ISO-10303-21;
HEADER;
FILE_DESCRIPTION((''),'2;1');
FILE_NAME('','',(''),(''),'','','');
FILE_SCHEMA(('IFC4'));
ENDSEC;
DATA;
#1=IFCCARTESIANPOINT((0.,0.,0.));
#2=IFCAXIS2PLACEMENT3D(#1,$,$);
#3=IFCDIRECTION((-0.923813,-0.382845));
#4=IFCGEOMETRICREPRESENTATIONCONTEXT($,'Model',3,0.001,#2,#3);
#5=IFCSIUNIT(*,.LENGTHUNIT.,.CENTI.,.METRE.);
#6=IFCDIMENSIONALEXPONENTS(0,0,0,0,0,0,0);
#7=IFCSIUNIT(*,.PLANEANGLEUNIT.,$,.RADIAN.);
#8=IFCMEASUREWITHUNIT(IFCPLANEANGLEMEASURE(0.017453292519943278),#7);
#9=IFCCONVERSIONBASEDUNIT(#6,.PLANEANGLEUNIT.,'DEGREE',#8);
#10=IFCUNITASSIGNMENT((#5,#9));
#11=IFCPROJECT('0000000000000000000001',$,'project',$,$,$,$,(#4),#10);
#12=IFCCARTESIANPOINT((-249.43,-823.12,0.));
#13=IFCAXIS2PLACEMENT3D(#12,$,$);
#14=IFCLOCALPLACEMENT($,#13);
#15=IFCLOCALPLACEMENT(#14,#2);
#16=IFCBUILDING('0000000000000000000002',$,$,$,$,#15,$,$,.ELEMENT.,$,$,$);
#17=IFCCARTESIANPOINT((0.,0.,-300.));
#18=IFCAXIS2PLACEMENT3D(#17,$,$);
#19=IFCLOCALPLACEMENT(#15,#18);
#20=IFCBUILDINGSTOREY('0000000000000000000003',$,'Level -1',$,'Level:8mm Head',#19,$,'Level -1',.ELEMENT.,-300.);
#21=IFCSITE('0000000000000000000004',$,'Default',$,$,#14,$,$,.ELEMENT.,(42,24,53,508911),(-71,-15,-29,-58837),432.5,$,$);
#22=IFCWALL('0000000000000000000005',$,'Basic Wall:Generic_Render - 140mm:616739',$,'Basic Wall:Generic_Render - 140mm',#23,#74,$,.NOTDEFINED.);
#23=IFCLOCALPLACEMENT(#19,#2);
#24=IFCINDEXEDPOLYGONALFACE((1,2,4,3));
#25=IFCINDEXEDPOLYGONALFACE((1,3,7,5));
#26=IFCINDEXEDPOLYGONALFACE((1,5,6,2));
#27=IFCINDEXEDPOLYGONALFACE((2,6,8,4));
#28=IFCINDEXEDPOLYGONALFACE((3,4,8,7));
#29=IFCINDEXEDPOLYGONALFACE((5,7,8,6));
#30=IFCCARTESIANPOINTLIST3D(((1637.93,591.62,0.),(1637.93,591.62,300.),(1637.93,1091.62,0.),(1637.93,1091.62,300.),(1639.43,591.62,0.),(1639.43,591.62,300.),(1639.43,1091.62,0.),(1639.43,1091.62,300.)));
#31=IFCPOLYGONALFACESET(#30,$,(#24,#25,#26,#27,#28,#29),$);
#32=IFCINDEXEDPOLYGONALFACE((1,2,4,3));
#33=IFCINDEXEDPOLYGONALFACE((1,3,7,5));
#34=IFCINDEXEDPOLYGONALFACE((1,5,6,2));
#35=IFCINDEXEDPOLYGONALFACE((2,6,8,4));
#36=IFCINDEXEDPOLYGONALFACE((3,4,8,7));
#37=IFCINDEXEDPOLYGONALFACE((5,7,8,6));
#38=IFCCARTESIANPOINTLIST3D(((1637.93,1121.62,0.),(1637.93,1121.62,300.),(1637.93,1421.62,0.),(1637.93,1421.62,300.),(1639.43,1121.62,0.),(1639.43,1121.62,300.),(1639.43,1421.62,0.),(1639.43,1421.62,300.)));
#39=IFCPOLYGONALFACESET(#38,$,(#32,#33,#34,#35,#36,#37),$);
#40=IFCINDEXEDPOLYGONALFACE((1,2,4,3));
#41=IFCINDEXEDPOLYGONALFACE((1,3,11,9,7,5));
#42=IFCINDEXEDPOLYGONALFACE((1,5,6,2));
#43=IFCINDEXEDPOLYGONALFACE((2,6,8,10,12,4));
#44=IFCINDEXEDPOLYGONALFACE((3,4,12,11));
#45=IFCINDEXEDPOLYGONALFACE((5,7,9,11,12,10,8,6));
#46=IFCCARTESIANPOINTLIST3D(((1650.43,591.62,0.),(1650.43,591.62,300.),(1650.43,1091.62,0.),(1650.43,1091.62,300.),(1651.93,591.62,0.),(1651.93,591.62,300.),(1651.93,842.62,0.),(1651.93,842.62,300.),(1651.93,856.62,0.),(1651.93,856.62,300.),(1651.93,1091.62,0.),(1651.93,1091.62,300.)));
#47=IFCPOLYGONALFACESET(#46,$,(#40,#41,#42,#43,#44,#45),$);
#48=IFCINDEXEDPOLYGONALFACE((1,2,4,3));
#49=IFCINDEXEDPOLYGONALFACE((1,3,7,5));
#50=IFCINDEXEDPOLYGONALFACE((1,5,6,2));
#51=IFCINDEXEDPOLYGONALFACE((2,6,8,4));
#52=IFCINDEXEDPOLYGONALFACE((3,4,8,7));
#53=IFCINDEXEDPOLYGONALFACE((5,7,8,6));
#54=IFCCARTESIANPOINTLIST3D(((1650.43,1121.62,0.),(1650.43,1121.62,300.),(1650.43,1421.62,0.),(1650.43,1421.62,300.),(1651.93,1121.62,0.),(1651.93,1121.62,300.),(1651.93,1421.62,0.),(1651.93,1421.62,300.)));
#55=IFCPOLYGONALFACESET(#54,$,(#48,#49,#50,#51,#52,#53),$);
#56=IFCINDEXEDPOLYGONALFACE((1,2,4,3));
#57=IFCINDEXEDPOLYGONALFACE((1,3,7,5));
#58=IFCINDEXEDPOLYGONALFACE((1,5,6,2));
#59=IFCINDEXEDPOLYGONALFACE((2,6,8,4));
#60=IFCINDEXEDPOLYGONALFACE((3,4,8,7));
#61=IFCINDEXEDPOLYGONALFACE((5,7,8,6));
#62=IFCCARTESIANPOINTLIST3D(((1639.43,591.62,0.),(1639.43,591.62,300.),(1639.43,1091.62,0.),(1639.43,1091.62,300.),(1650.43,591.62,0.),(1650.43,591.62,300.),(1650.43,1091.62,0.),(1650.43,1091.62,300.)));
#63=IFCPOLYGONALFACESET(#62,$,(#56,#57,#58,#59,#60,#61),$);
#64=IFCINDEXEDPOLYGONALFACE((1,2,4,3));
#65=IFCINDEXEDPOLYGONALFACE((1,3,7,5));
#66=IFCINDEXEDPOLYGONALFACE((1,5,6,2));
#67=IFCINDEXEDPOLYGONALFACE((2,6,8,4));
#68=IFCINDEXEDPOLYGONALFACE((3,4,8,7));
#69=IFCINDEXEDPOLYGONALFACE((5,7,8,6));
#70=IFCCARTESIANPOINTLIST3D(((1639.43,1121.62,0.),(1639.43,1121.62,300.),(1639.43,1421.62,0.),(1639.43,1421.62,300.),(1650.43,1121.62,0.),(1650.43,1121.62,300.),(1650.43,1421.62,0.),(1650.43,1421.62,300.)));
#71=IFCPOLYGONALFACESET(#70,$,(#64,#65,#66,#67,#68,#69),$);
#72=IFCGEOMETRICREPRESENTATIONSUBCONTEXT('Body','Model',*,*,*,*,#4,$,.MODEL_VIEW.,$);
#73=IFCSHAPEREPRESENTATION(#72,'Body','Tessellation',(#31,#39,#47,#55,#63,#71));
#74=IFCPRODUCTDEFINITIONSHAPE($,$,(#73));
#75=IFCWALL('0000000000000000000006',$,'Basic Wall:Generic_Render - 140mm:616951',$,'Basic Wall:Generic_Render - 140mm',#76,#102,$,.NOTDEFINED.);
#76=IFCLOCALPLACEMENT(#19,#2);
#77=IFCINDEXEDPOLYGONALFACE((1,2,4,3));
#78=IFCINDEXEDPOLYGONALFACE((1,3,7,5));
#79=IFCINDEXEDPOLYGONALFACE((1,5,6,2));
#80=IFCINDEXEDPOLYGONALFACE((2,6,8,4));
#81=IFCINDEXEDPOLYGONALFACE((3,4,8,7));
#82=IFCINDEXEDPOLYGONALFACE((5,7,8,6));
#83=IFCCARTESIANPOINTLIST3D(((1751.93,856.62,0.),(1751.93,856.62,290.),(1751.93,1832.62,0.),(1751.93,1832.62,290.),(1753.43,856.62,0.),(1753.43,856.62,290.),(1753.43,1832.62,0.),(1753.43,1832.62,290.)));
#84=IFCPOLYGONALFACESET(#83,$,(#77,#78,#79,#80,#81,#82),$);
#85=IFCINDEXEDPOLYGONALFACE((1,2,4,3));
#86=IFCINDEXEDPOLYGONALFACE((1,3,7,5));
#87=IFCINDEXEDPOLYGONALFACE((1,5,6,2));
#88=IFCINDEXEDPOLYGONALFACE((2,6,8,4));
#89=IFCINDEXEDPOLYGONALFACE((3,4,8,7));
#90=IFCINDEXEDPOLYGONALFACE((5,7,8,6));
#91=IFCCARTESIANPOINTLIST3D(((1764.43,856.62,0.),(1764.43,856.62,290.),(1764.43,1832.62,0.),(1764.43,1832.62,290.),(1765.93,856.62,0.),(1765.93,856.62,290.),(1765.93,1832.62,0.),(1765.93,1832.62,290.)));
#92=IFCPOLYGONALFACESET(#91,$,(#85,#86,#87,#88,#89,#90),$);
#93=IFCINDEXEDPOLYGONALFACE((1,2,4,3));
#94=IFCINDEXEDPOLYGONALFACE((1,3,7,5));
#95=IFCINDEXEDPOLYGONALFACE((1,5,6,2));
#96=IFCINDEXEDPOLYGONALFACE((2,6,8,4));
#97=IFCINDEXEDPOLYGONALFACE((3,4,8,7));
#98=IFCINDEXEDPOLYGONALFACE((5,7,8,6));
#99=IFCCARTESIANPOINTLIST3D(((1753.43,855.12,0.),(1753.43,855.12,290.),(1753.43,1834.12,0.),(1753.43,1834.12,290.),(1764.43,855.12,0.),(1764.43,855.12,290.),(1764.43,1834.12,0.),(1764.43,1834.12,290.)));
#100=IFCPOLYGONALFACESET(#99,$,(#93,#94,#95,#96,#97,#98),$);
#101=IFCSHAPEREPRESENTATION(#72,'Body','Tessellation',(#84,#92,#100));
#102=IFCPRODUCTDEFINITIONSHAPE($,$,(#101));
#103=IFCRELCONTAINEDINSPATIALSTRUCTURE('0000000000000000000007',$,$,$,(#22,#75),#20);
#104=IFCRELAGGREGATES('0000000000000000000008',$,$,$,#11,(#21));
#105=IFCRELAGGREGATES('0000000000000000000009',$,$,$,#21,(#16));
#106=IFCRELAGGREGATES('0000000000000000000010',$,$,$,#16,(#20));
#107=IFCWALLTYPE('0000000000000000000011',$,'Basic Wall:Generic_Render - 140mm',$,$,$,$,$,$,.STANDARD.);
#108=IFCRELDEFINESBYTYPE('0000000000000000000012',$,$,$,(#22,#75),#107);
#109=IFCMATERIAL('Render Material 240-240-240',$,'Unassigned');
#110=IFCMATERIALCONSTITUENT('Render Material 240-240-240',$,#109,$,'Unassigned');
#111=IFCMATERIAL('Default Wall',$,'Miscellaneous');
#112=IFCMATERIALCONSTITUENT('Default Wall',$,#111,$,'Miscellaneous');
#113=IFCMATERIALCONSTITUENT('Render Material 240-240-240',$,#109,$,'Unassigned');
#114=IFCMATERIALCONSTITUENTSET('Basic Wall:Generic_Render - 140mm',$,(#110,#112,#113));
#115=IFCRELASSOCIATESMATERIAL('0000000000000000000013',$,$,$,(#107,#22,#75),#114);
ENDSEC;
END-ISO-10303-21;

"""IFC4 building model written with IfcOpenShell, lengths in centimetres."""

from ifc_helpers import new_model, entity, si_unit, converted_unit, direction, frame, origin, place, context, subcontext, project, spatial, indexed_curve, outline, extrude, material, constituent, constituent_set, type_object, element, save


model = new_model("IFC4")

# Units and contexts
model_context = context("Model", 3, precision=0.001, world=origin(), true_north=direction((-0.923813, -0.382845)))
body_context = subcontext(model_context, "Body", "Model", "MODEL_VIEW")
ifc_project = project(units=[si_unit("LENGTHUNIT", "METRE", prefix="CENTI"), converted_unit("PLANEANGLEUNIT", "DEGREE", entity("IfcPlaneAngleMeasure", 0.017453292519943278), si_unit("PLANEANGLEUNIT", "RADIAN"), dimensions=[0, 0, 0, 0, 0, 0, 0])], contexts=[model_context])

# Site, building, storey
site_placement = place(None, frame((-249.43, -823.12, 0.0)))
site = spatial("IfcSite", under=ifc_project, at=site_placement, Name="Default", CompositionType="ELEMENT", RefLatitude=(42, 24, 53, 508911), RefLongitude=(-71, -15, -29, -58837), RefElevation=432.5)
building_placement = place(site_placement, origin())
building = spatial("IfcBuilding", under=site, at=building_placement, CompositionType="ELEMENT")
storey_placement = place(building_placement, frame((0.0, 0.0, -300.0)))
storey = spatial("IfcBuildingStorey", under=building, at=storey_placement, Name="Level -1", ObjectType="Level:8mm Head", LongName="Level -1", CompositionType="ELEMENT", Elevation=-300.0)

# Shared definitions
ifc_material_1 = material(Name="Render Material 240-240-240", Category="Unassigned")
ifc_constituent_1 = constituent(ifc_material_1, Name="Render Material 240-240-240", Category="Unassigned")
ifc_material_2 = material(Name="Default Wall", Category="Miscellaneous")
ifc_constituent_2 = constituent(ifc_material_2, Name="Default Wall", Category="Miscellaneous")
ifc_constituent_3 = constituent(ifc_material_1, Name="Render Material 240-240-240", Category="Unassigned")
ifc_constituent_set_1 = constituent_set(constituents=[ifc_constituent_1, ifc_constituent_2, ifc_constituent_3], Name="Basic Wall:Generic_Render - 140mm")
wall_type_1 = type_object("IfcWallType", Name="Basic Wall:Generic_Render - 140mm", PredefinedType="STANDARD", material=ifc_constituent_set_1)

# Walls
wall_1_placement = place(storey_placement, frame((1644.93, 1421.62, 0.0), z_axis=(0.0, 0.0, 1.0), x_axis=(0.0, -1.0, 0.0)))
element("IfcWall", 1, at=wall_1_placement, inside=storey, type_object=wall_type_1, material=ifc_constituent_set_1, Name="Basic Wall:Generic_Render - 140mm:616739", ObjectType="Basic Wall:Generic_Render - 140mm", PredefinedType="NOTDEFINED", context=body_context, shape_type="SweptSolid", body=[
    extrude(outline(indexed_curve([(-250.0, -0.75), (250.0, -0.75), (250.0, 0.75), (-250.0, 0.75), (-250.0, -0.75)], self_intersect=False)), frame((580.0, -6.25, 0.0), z_axis=(0.0, 0.0, 1.0), x_axis=(-1.0, 0.0, 0.0)), (0.0, 0.0, 1.0), 300.0),
    extrude(outline(indexed_curve([(-0.75, -150.0), (0.75, -150.0), (0.75, 150.0), (-0.75, 150.0), (-0.75, -150.0)], self_intersect=False)), frame((150.0, -6.25, 0.0), z_axis=(0.0, 0.0, 1.0), x_axis=(0.0, 1.0, 0.0)), (0.0, 0.0, 1.0), 300.0),
    extrude(outline(indexed_curve([(-252.67, -0.5), (-1.67, -0.5), (12.33, -0.5), (247.33, -0.5), (247.33, 1.0), (-252.67, 1.0), (-252.67, -0.5)], self_intersect=False)), frame((577.33, 6.5, 0.0), z_axis=(0.0, 0.0, 1.0), x_axis=(-1.0, 0.0, 0.0)), (0.0, 0.0, 1.0), 300.0),
    extrude(outline(indexed_curve([(-0.75, -150.0), (0.75, -150.0), (0.75, 150.0), (-0.75, 150.0), (-0.75, -150.0)], self_intersect=False)), frame((150.0, 6.25, 0.0), z_axis=(0.0, 0.0, 1.0), x_axis=(0.0, -1.0, 0.0)), (0.0, 0.0, 1.0), 300.0),
    extrude(outline(indexed_curve([(-250.0, -5.5), (250.0, -5.5), (250.0, 5.5), (-250.0, 5.5), (-250.0, -5.5)], self_intersect=False)), frame((580.0, 0.0, 0.0), z_axis=(0.0, 0.0, 1.0), x_axis=(-1.0, 0.0, 0.0)), (0.0, 0.0, 1.0), 300.0),
    extrude(outline(indexed_curve([(-5.5, -150.0), (5.5, -150.0), (5.5, 150.0), (-5.5, 150.0), (-5.5, -150.0)], self_intersect=False)), frame((150.0, 0.0, 0.0), z_axis=(0.0, 0.0, 1.0), x_axis=(0.0, -1.0, 0.0)), (0.0, 0.0, 1.0), 300.0),
])
wall_2_placement = place(storey_placement, frame((1758.93, 1832.62, 0.0), z_axis=(0.0, 0.0, 1.0), x_axis=(0.0, -1.0, 0.0)))
element("IfcWall", 2, at=wall_2_placement, inside=storey, type_object=wall_type_1, material=ifc_constituent_set_1, Name="Basic Wall:Generic_Render - 140mm:616951", ObjectType="Basic Wall:Generic_Render - 140mm", PredefinedType="NOTDEFINED", context=body_context, shape_type="SweptSolid", body=[
    extrude(outline(indexed_curve([(-145.0, -488.0), (145.0, -488.0), (145.0, 488.0), (-145.0, 488.0), (-145.0, -488.0)], self_intersect=False)), frame((488.0, -7.0, 145.0), z_axis=(0.0, 1.0, 0.0), x_axis=(0.0, 0.0, 1.0)), (0.0, 0.0, 1.0), 1.5),
    extrude(outline(indexed_curve([(-145.0, -488.0), (145.0, -488.0), (145.0, 488.0), (-145.0, 488.0), (-145.0, -488.0)], self_intersect=False)), frame((488.0, 5.5, 145.0), z_axis=(0.0, 1.0, 0.0), x_axis=(0.0, 0.0, 1.0)), (0.0, 0.0, 1.0), 1.5),
    extrude(outline(indexed_curve([(-145.0, -489.5), (145.0, -489.5), (145.0, 489.5), (-145.0, 489.5), (-145.0, -489.5)], self_intersect=False)), frame((488.0, -5.5, 145.0), z_axis=(0.0, 1.0, 0.0), x_axis=(0.0, 0.0, 1.0)), (0.0, 0.0, 1.0), 11.0),
])

save(model, "model.ifc")
